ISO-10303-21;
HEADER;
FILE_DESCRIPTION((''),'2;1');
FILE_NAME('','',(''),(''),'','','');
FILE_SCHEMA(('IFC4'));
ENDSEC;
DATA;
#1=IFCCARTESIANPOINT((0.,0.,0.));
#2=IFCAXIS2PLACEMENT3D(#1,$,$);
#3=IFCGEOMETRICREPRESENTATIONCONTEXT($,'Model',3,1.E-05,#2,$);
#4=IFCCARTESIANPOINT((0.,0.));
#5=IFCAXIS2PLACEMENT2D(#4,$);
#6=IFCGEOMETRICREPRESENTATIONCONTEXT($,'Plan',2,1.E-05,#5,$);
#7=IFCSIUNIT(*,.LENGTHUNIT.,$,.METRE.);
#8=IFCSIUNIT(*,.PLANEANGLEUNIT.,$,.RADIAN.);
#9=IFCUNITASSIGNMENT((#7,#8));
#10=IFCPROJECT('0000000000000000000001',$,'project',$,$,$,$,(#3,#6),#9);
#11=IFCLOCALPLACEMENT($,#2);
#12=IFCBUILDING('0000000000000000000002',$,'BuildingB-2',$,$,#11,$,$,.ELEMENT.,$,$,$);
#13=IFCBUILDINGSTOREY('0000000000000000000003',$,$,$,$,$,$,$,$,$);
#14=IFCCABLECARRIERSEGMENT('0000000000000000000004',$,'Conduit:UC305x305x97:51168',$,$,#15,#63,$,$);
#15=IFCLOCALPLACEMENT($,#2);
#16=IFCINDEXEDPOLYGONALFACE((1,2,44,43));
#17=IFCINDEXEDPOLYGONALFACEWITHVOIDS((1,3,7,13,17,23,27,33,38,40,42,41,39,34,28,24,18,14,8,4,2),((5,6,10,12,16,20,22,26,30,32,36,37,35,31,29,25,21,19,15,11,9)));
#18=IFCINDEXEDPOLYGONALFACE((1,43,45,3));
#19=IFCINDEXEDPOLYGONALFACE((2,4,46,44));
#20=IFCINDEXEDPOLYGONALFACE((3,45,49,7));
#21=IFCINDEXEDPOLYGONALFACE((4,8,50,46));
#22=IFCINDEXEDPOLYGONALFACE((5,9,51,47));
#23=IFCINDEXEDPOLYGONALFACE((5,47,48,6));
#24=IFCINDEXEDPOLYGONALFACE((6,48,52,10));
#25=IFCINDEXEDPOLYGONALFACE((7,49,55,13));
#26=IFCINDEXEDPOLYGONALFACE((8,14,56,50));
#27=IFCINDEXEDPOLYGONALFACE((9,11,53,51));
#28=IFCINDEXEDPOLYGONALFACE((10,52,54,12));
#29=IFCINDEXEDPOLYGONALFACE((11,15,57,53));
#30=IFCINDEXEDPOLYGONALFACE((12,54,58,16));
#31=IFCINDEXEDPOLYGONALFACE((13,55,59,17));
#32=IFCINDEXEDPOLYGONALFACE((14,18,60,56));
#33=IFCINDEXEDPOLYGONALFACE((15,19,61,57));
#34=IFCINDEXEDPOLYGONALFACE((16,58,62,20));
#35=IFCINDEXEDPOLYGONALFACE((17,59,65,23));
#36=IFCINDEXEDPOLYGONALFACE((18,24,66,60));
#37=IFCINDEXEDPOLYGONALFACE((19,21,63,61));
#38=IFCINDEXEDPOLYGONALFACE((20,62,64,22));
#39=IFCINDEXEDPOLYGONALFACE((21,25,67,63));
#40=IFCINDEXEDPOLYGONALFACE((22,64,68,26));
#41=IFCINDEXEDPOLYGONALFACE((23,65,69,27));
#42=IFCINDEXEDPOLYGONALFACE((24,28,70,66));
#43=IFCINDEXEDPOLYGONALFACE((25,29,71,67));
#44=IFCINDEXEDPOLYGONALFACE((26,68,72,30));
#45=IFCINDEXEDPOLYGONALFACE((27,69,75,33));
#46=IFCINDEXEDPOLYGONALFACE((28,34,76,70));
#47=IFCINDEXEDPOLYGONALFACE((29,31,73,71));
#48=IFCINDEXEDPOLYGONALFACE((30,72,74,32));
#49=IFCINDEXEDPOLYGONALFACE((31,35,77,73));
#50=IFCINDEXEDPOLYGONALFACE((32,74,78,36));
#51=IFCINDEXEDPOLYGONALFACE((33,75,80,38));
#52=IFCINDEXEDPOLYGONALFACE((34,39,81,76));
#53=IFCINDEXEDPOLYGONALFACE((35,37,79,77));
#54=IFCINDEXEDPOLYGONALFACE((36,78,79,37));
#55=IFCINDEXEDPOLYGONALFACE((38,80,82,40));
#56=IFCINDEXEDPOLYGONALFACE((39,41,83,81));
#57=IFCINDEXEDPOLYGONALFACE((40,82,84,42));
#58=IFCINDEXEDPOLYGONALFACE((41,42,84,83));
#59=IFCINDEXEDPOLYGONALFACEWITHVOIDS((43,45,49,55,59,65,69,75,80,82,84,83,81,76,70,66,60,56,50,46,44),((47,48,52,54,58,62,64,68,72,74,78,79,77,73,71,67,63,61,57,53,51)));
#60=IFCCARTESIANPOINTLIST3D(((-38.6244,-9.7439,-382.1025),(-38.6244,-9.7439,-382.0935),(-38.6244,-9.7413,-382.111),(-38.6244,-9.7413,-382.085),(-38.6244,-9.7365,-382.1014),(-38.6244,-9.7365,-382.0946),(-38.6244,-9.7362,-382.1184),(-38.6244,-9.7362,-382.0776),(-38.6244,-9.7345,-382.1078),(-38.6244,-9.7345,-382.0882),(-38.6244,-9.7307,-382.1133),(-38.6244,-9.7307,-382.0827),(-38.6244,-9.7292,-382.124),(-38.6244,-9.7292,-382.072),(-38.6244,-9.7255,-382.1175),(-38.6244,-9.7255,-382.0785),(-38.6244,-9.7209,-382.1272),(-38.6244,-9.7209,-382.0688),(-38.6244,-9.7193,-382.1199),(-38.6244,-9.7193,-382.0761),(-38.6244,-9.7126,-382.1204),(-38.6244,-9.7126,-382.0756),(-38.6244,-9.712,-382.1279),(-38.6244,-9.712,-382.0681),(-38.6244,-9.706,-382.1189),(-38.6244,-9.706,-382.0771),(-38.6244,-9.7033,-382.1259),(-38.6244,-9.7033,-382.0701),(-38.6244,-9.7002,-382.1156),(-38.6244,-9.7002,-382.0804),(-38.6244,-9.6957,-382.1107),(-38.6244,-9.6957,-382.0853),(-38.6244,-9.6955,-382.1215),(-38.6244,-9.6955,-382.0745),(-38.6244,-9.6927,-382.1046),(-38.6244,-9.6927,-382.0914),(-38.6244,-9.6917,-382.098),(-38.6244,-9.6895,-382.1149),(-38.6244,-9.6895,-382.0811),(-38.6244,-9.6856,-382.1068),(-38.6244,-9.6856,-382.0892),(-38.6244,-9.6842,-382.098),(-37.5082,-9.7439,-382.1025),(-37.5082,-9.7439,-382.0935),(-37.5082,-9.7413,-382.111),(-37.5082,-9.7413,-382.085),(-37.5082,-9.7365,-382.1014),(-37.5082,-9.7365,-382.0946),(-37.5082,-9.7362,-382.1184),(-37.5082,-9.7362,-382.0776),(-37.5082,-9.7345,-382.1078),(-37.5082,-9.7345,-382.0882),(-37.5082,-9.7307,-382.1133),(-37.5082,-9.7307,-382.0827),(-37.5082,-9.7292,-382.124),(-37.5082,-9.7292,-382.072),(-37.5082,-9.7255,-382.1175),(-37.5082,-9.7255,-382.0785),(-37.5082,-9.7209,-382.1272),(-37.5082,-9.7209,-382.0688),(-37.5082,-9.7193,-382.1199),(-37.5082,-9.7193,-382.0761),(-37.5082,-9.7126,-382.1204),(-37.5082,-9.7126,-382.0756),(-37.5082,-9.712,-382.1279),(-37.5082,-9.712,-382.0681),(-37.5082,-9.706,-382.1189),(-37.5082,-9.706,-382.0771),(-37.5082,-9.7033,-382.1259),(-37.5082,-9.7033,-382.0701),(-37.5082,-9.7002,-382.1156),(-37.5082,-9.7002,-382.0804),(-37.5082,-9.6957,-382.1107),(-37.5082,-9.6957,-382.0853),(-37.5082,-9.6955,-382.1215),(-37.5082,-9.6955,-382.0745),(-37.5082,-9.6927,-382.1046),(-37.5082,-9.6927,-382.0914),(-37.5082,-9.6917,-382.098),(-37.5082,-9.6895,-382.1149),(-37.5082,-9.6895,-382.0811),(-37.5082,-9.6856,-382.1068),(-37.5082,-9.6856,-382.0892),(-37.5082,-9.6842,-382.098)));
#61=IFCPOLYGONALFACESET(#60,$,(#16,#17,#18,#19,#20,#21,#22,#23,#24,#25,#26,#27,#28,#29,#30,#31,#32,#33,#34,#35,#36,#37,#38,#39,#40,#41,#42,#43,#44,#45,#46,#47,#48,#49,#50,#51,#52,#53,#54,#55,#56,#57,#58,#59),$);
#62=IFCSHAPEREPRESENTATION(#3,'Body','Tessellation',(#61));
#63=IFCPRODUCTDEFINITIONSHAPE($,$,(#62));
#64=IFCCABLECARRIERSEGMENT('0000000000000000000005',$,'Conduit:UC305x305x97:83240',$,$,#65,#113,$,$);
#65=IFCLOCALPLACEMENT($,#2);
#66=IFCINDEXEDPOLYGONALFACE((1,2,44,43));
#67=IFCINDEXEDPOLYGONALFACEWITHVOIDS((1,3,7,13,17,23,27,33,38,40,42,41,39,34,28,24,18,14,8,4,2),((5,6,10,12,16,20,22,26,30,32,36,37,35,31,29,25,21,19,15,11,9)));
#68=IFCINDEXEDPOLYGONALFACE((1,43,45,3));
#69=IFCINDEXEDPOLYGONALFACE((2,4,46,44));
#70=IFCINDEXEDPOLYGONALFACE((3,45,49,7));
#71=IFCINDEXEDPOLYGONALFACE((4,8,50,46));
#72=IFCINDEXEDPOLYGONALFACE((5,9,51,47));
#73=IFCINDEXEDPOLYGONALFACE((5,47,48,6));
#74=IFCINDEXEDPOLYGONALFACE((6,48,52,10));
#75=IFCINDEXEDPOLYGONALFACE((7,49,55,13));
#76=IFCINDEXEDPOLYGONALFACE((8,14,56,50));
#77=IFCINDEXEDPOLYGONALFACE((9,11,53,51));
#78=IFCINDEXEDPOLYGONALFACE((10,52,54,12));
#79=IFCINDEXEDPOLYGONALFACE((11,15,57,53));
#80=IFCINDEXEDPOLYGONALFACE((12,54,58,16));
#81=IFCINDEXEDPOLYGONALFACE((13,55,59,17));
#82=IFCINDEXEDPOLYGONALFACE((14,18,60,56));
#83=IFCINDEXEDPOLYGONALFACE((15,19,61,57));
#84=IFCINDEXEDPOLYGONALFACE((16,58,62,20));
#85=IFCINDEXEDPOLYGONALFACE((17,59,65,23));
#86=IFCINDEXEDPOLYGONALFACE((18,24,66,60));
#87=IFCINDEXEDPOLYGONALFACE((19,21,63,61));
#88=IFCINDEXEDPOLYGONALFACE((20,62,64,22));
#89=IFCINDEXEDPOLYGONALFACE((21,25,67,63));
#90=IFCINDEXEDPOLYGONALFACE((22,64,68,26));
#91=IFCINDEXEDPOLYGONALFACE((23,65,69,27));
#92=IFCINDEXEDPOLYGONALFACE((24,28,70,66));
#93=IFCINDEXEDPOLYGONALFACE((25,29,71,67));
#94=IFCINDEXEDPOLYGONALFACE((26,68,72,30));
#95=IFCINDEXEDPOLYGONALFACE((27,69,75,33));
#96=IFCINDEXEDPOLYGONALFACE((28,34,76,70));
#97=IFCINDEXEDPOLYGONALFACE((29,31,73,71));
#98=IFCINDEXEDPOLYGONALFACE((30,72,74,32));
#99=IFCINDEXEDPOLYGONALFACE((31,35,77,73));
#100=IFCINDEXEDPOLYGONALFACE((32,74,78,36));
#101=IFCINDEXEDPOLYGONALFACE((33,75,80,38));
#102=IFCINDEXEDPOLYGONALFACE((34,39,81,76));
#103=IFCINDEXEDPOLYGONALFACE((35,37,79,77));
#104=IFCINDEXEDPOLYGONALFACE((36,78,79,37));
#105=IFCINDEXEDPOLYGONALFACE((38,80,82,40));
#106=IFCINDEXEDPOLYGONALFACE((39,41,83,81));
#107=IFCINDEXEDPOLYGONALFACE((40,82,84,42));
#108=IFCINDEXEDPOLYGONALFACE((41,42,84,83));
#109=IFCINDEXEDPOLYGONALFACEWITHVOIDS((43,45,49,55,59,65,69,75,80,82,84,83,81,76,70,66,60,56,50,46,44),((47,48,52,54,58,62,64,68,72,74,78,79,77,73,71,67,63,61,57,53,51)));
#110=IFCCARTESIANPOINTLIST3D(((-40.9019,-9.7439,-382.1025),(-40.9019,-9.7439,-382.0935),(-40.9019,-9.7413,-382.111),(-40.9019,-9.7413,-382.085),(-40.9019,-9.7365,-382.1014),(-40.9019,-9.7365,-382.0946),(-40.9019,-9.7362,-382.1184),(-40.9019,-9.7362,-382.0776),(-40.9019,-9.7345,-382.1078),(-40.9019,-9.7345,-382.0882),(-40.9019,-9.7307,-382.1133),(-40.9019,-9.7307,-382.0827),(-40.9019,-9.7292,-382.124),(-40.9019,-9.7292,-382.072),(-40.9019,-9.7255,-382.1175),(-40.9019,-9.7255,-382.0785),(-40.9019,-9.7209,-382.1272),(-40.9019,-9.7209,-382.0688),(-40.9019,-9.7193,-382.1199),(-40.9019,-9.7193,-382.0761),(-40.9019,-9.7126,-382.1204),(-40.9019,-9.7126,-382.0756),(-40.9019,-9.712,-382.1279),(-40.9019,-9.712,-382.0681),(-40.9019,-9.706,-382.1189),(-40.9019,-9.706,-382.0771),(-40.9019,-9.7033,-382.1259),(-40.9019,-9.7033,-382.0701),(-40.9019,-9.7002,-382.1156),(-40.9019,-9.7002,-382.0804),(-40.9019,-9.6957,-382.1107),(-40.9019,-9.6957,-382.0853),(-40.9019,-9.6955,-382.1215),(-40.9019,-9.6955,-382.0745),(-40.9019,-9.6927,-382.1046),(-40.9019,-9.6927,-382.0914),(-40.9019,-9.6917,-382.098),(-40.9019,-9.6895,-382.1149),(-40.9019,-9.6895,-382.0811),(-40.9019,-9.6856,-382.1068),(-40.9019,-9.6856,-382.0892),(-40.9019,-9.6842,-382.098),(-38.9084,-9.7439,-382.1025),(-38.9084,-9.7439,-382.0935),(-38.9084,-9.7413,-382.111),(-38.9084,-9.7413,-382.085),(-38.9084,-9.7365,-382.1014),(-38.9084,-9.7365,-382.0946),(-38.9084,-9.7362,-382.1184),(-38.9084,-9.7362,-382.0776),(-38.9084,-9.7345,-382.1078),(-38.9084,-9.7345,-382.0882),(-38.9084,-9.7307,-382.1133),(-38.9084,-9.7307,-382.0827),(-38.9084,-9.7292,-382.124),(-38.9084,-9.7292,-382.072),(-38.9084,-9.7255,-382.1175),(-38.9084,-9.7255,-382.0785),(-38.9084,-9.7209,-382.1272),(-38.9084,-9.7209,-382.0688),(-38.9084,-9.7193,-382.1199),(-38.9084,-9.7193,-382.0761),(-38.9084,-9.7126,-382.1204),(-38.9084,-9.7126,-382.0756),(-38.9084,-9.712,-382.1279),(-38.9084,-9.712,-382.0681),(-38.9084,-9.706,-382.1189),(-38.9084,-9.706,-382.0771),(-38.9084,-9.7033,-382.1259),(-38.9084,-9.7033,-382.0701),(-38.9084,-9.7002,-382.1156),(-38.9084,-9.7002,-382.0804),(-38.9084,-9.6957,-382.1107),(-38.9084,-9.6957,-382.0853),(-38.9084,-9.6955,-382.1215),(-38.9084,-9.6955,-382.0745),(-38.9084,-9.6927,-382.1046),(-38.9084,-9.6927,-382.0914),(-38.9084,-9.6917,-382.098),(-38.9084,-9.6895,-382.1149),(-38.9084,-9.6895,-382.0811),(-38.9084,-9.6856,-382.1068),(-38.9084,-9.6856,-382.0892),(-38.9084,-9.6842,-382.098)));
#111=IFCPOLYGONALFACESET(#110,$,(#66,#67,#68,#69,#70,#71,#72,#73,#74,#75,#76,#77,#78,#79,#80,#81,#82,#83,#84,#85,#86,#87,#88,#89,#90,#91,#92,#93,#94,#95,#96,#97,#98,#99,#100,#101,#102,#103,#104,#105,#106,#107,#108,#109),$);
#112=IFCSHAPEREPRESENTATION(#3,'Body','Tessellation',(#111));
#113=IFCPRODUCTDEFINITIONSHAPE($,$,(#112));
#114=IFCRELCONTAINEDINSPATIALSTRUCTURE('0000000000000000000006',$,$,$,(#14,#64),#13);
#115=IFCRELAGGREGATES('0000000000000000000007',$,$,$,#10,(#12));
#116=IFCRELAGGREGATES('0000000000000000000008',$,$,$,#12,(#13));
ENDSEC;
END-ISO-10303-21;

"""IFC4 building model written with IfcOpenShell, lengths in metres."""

from ifc_helpers import new_model, entity, si_unit, origin, origin_2d, place, context, project, spatial, element, save


model = new_model("IFC4")

# Units and contexts
model_context = context("Model", 3, precision=1e-05, world=origin())
plan_context = context("Plan", 2, precision=1e-05, world=origin_2d())
ifc_project = project(units=[si_unit("LENGTHUNIT", "METRE"), si_unit("PLANEANGLEUNIT", "RADIAN")], contexts=[model_context, plan_context])

# Building, storey
building_placement = place(None, origin())
building = spatial("IfcBuilding", under=ifc_project, at=building_placement, Name="BuildingB-2", CompositionType="ELEMENT")
storey = spatial("IfcBuildingStorey", under=building)

# Cable carrier segments
element("IfcCableCarrierSegment", 1, inside=storey, Name="Conduit:UC305x305x97:51168", context=model_context, shape_type="AdvancedSweptSolid", body=[
    entity("IfcSweptDiskSolid", entity("IfcCompositeCurve", [entity("IfcCompositeCurveSegment", "CONTINUOUS", False, entity("IfcPolyline", [entity("IfcCartesianPoint", [37.5082, 9.7142, 382.098]), entity("IfcCartesianPoint", [38.6244, 9.7142, 382.098])]))], False), 0.03, 0.0225),
])
element("IfcCableCarrierSegment", 2, inside=storey, Name="Conduit:UC305x305x97:83240", context=model_context, shape_type="AdvancedSweptSolid", body=[
    entity("IfcSweptDiskSolid", entity("IfcCompositeCurve", [entity("IfcCompositeCurveSegment", "CONTINUOUS", False, entity("IfcPolyline", [entity("IfcCartesianPoint", [38.9084, 9.7142, 382.098]), entity("IfcCartesianPoint", [40.9019, 9.7142, 382.098])]))], False), 0.03, 0.0225),
])

save(model, "model.ifc")
